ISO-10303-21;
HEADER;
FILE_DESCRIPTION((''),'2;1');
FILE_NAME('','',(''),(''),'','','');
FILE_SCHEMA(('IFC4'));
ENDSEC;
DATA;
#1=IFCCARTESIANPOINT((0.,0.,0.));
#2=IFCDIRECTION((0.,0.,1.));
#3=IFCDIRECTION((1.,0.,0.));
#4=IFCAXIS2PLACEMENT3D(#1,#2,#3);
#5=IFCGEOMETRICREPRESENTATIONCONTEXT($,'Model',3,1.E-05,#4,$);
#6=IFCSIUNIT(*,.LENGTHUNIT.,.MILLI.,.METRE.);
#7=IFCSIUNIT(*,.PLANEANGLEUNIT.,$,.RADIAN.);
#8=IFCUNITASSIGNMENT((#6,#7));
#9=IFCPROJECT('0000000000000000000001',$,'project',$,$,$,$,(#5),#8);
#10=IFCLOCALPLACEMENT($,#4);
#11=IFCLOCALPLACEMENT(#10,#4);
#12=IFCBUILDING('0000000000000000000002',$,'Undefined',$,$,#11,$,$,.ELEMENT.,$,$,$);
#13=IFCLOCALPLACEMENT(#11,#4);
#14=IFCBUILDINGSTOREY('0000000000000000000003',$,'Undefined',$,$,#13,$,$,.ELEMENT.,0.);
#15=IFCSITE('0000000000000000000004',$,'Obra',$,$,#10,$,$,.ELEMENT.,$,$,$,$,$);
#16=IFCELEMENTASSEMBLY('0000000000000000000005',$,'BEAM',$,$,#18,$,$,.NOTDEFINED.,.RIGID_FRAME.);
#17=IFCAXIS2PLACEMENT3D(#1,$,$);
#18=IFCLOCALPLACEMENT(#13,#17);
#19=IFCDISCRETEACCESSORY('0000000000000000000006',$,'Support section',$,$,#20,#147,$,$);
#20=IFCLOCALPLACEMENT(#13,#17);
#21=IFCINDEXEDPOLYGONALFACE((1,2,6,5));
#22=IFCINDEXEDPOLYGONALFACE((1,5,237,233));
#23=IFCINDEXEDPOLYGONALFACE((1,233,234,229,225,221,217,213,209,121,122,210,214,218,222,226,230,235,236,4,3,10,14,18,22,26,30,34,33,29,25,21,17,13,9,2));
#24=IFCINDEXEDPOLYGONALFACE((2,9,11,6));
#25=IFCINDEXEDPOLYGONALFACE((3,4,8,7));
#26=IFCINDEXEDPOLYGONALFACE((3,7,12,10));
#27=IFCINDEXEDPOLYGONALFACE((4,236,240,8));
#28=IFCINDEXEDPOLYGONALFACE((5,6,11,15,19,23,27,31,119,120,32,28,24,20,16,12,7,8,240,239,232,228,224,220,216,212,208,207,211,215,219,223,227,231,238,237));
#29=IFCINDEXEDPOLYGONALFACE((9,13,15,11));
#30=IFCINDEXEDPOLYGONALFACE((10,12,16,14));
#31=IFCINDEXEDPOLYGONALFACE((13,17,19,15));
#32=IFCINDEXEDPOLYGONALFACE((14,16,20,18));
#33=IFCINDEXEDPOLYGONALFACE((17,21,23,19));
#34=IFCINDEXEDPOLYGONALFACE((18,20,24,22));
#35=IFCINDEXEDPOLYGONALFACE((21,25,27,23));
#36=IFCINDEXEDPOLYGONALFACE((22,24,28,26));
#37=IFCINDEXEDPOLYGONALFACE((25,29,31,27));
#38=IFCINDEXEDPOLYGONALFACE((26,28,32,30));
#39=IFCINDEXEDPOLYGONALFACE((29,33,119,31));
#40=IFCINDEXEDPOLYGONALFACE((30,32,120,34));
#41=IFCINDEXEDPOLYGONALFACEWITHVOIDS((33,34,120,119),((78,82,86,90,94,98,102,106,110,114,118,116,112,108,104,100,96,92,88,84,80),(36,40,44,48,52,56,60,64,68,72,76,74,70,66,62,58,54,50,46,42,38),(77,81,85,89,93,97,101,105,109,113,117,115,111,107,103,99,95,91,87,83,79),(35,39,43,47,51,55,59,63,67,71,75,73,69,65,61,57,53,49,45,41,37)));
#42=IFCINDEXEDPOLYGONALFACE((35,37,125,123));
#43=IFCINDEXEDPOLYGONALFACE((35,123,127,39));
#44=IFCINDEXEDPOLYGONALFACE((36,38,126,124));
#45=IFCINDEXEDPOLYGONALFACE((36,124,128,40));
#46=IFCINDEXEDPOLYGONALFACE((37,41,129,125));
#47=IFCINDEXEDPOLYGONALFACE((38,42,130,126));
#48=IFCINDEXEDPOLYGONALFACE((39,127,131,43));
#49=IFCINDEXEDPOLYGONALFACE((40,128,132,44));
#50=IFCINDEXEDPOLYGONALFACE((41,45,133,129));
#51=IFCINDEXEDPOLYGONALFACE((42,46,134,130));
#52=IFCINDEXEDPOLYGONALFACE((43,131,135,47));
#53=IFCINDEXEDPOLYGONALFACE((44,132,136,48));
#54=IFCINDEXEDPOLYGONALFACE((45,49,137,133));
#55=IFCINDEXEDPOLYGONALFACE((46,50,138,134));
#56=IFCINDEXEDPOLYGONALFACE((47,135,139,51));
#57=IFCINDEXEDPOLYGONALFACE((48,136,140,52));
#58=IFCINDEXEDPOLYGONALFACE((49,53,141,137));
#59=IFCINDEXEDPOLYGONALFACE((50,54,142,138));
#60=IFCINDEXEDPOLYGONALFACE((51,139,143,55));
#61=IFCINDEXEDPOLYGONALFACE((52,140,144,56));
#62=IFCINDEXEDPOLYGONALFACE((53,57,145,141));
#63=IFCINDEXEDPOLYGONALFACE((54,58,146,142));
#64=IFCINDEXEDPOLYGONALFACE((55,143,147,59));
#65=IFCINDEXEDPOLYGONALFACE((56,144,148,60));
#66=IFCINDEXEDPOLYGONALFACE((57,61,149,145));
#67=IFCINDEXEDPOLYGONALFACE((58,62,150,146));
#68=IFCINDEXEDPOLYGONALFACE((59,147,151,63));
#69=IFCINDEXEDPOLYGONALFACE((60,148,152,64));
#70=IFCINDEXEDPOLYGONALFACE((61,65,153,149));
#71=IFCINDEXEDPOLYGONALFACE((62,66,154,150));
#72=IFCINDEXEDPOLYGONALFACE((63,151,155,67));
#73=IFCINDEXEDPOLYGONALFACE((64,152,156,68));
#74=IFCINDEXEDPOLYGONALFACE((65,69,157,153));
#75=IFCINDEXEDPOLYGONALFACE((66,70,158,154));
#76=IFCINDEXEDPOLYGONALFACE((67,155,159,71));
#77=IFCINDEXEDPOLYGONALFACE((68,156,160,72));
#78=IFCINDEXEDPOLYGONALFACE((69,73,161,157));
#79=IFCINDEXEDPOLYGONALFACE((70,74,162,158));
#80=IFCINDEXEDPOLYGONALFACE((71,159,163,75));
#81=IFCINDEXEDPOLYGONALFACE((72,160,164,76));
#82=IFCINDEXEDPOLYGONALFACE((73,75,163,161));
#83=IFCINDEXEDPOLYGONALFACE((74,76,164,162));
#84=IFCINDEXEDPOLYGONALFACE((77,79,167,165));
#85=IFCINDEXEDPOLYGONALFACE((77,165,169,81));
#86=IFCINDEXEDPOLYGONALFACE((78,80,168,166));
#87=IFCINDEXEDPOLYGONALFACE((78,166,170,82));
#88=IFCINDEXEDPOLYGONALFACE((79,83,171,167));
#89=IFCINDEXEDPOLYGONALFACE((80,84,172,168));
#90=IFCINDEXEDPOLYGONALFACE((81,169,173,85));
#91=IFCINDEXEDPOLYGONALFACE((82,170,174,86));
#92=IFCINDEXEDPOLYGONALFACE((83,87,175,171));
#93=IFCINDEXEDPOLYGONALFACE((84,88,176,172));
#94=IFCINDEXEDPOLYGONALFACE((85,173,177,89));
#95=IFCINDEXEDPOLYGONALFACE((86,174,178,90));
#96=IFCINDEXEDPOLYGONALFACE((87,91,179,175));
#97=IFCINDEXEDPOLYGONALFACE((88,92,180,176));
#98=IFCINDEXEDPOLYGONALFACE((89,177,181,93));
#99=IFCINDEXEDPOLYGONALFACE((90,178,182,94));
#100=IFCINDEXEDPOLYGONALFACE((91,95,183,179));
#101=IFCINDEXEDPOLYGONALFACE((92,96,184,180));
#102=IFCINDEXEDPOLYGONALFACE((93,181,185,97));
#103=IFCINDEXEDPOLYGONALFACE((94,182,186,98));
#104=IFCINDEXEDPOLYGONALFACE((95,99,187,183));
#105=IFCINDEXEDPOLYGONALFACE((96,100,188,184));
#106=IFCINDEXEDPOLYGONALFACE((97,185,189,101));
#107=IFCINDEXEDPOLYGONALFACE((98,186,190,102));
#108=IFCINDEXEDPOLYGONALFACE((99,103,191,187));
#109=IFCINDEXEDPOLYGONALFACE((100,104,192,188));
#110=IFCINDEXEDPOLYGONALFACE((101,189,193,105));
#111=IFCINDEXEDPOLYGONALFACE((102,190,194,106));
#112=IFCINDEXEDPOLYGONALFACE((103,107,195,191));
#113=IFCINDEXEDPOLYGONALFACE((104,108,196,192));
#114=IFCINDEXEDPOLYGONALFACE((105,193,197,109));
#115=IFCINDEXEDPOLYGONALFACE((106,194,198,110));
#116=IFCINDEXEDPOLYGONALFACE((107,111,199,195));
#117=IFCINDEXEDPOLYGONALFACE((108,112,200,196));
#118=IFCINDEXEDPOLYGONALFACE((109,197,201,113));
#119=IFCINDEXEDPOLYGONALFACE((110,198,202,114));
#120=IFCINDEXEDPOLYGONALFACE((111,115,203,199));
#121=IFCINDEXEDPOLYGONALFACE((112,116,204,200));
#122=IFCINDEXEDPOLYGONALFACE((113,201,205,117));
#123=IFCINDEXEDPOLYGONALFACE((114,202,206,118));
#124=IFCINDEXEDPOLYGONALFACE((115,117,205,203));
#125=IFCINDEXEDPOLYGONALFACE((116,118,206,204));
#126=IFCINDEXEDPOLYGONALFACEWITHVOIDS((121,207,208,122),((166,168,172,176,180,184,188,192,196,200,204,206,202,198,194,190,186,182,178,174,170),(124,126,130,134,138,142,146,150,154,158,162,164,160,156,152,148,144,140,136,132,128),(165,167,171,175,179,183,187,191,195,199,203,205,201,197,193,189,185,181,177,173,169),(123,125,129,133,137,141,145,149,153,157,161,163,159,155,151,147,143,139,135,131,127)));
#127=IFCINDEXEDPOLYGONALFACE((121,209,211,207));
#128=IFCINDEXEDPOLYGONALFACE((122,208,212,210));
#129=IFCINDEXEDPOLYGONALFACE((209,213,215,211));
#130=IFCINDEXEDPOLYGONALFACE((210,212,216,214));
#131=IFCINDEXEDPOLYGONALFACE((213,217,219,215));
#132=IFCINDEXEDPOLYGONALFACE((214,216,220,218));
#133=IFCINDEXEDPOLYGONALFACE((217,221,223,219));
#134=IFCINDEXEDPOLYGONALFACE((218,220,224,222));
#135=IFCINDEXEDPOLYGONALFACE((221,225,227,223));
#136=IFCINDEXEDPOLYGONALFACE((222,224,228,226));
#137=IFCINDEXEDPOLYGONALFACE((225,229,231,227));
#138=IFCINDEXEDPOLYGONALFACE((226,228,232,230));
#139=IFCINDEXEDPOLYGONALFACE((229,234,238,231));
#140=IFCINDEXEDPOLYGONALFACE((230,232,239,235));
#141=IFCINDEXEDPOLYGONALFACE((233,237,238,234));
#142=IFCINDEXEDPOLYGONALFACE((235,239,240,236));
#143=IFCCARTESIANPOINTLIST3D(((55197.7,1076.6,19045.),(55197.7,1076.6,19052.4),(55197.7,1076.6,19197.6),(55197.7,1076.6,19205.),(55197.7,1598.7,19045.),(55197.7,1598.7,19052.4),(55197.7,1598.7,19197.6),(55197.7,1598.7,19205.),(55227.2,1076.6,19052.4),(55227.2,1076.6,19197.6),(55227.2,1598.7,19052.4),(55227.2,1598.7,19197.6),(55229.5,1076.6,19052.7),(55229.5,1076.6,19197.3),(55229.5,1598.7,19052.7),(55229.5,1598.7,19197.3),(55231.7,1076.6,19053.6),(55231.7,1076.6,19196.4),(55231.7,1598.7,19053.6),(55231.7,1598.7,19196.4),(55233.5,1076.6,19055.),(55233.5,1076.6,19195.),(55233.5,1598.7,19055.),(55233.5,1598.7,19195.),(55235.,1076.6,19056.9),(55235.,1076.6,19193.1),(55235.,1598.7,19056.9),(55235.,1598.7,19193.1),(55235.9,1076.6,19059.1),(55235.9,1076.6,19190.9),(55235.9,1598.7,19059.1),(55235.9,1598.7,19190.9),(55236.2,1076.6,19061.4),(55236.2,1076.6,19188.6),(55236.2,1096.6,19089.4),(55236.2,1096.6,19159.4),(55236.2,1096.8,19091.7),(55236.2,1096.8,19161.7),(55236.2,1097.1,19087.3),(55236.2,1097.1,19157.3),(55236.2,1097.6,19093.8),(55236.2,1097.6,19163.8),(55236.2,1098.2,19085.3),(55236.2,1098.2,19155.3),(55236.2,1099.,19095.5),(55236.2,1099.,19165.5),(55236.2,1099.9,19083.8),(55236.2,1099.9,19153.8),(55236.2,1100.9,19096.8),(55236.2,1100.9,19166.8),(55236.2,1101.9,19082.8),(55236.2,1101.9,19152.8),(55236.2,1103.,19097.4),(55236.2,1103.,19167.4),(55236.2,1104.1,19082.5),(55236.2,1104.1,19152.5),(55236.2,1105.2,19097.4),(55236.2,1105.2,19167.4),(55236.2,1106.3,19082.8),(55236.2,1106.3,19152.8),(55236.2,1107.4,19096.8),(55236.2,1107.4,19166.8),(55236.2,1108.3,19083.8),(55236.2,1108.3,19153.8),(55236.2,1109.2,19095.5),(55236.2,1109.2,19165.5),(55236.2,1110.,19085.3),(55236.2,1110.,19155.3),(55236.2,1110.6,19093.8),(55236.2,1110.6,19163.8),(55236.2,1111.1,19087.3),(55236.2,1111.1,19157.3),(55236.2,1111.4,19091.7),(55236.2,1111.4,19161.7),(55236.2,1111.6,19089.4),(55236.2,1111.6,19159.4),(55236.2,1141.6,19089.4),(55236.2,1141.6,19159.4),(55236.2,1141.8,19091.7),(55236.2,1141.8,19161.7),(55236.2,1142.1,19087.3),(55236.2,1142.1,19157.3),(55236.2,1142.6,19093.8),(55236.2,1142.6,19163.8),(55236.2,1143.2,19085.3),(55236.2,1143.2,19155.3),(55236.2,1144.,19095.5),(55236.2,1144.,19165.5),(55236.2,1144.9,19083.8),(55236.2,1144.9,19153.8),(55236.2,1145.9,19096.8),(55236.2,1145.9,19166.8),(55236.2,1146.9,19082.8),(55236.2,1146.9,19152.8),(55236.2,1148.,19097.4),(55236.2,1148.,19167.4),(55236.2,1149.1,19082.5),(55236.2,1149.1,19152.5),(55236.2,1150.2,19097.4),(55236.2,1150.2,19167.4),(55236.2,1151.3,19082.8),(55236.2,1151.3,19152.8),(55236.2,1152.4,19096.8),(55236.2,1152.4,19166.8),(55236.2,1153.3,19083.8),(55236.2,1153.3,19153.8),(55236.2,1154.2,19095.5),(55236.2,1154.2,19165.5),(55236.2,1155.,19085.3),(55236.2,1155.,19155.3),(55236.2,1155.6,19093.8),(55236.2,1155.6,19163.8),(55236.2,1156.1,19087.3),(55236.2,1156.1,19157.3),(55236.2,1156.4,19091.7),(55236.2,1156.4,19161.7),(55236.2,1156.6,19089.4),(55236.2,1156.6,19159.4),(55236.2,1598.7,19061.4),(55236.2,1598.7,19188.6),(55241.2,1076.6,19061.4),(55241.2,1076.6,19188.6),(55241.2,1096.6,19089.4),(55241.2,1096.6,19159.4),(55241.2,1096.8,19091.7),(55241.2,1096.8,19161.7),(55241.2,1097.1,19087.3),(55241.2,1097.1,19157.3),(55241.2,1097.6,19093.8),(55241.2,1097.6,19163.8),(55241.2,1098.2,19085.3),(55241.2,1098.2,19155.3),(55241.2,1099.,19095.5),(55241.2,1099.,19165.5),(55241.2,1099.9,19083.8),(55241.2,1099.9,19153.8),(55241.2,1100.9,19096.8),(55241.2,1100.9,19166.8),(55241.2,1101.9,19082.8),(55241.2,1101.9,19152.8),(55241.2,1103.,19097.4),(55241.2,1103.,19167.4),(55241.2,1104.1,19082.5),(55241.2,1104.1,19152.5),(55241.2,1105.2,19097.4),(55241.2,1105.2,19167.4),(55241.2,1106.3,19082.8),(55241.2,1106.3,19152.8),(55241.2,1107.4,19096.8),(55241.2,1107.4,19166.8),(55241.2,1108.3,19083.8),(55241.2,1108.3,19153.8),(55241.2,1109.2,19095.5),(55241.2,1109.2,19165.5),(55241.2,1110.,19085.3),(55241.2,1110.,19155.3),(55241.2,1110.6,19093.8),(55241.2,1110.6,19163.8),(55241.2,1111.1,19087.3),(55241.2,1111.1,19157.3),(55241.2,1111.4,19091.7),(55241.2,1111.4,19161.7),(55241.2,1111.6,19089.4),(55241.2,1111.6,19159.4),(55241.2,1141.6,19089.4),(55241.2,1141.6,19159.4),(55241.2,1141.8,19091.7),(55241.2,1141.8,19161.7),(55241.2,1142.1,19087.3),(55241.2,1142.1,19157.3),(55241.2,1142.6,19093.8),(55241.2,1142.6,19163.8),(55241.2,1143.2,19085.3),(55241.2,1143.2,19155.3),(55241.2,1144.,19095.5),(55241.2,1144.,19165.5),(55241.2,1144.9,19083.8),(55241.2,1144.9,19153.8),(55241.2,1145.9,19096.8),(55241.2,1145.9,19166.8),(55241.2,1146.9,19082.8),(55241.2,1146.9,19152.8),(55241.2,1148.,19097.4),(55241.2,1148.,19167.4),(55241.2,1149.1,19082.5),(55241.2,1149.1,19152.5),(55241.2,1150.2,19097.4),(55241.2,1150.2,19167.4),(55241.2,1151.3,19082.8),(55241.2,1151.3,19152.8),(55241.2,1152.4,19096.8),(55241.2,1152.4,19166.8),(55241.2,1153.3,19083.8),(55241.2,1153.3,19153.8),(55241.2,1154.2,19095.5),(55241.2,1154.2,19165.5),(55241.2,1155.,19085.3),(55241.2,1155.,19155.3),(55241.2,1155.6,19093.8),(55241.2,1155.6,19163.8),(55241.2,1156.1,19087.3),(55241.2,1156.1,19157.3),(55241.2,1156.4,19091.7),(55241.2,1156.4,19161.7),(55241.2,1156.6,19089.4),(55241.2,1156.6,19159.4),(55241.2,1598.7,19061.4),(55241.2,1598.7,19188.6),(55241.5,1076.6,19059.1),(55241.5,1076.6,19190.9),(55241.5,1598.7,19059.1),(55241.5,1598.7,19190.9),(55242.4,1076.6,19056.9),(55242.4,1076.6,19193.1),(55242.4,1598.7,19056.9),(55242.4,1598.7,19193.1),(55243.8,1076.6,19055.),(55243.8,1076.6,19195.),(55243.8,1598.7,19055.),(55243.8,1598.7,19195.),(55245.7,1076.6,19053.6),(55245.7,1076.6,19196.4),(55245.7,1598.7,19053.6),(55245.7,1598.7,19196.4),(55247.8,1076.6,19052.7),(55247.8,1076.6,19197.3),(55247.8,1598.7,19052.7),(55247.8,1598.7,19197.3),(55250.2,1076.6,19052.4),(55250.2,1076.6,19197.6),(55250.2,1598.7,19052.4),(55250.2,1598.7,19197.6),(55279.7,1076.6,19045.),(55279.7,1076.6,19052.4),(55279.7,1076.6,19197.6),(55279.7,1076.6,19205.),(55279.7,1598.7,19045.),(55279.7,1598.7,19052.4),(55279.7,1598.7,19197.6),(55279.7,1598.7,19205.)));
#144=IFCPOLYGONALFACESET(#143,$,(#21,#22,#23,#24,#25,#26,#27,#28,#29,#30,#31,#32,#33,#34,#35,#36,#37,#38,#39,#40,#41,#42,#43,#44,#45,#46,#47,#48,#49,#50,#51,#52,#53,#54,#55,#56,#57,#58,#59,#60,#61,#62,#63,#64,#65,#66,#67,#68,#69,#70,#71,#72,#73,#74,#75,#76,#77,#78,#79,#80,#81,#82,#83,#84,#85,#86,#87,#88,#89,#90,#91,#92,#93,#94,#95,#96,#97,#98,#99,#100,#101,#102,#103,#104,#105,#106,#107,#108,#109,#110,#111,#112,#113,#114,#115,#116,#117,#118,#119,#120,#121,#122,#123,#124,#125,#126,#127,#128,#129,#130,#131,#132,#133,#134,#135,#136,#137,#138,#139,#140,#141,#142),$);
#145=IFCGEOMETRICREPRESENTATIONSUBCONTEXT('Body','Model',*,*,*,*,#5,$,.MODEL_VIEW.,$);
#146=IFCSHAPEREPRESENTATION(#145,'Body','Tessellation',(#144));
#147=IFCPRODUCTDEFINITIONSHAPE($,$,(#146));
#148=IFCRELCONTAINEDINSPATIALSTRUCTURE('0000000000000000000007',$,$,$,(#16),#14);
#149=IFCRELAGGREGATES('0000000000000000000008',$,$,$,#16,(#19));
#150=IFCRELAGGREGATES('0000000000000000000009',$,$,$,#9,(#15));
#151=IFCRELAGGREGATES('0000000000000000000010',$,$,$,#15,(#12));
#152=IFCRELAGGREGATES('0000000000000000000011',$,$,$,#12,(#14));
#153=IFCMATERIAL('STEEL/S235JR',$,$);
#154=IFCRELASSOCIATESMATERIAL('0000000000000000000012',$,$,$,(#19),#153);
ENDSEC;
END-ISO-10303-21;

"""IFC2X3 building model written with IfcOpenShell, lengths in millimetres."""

from ifc_helpers import new_model, si_unit, frame, origin_with_axes, origin_2d_with_axis, place, context, subcontext, project, spatial, circle, i_section, extrude, clip, halfspace, source, transform, mapped, material, element, aggregate, save


model = new_model("IFC2X3")

# Units and contexts
model_context = context("Model", 3, precision=1e-05, world=origin_with_axes())
body_context = subcontext(model_context, "Body", "Model", "MODEL_VIEW")
ifc_project = project(units=[si_unit("LENGTHUNIT", "METRE", prefix="MILLI"), si_unit("PLANEANGLEUNIT", "RADIAN")], contexts=[model_context])

# Site, building, storey
site_placement = place(None, origin_with_axes())
site = spatial("IfcSite", under=ifc_project, at=site_placement, Name="Obra", CompositionType="ELEMENT")
building_placement = place(site_placement, origin_with_axes())
building = spatial("IfcBuilding", under=site, at=building_placement, Name="Undefined", CompositionType="ELEMENT")
storey_placement = place(building_placement, origin_with_axes())
storey = spatial("IfcBuildingStorey", under=building, at=storey_placement, Name="Undefined", CompositionType="ELEMENT", Elevation=0.0)

# Element assembly
ifc_material_1 = material(Name="STEEL/S235JR")
assembly_1_placement = place(storey_placement, origin_with_axes())
assembly_1 = element("IfcElementAssembly", 1, at=assembly_1_placement, inside=storey, Name="BEAM", AssemblyPlace="NOTDEFINED", PredefinedType="RIGID_FRAME")

# Discrete accessory, opening
shared_shape_1 = source(origin_with_axes(), body_context, "Body", "SweptSolid", [
    extrude(circle(Radius=7.5, at=origin_2d_with_axis()), frame((0.0, -2.6, 0.0), z_axis=(0.0, 1.0, 0.0), x_axis=(1.0, 0.0, 0.0)), (0.0, 0.0, 1.0), 5.2),
])
discrete_accessory_1_placement = place(assembly_1_placement, frame((55238.7, 1086.6, 19125.0), z_axis=(0.0, 0.0, 1.0), x_axis=(0.0, 1.0, 0.0)))
discrete_accessory_1 = element("IfcDiscreteAccessory", 2, at=discrete_accessory_1_placement, material=ifc_material_1, Name="Support section", context=body_context, shape_type="Clipping", body=[
    clip(clip(extrude(i_section(OverallWidth=82.0, OverallDepth=160.0, WebThickness=5.0, FlangeThickness=7.4, FilletRadius=9.0, at=origin_2d_with_axis()), frame((512.1, 0.0, 0.0), z_axis=(-1.0, 0.0, 0.0), x_axis=(0.0, -1.0, 0.0)), (0.0, 0.0, 1.0), 522.1), halfspace(frame((512.1, 0.0, 580.0), z_axis=(1.0, 0.0, 0.0), x_axis=(0.0, 1.0, 0.0)), False)), halfspace(frame((-10.0, 0.0, -180.0), z_axis=(1.0, 0.0, 0.0), x_axis=(0.0, -1.0, 0.0)), True)),
])
opening_1_placement = place(assembly_1_placement, frame((55238.7, 1126.6, 19160.0), z_axis=(0.0, 1.0, 0.0), x_axis=(0.0, 0.0, -1.0)))
element("IfcOpeningElement", 3, at=opening_1_placement, cuts=discrete_accessory_1, ObjectType="Opening", context=body_context, shape_type="MappedRepresentation", body=[
    mapped(shared_shape_1, transform((0.0, 0.0, -22.5))),
    mapped(shared_shape_1, transform((70.0, 0.0, -22.5))),
    mapped(shared_shape_1, transform((0.0, 0.0, 22.5))),
    mapped(shared_shape_1, transform((70.0, 0.0, 22.5))),
])

aggregate(assembly_1, [discrete_accessory_1])

save(model, "model.ifc")
